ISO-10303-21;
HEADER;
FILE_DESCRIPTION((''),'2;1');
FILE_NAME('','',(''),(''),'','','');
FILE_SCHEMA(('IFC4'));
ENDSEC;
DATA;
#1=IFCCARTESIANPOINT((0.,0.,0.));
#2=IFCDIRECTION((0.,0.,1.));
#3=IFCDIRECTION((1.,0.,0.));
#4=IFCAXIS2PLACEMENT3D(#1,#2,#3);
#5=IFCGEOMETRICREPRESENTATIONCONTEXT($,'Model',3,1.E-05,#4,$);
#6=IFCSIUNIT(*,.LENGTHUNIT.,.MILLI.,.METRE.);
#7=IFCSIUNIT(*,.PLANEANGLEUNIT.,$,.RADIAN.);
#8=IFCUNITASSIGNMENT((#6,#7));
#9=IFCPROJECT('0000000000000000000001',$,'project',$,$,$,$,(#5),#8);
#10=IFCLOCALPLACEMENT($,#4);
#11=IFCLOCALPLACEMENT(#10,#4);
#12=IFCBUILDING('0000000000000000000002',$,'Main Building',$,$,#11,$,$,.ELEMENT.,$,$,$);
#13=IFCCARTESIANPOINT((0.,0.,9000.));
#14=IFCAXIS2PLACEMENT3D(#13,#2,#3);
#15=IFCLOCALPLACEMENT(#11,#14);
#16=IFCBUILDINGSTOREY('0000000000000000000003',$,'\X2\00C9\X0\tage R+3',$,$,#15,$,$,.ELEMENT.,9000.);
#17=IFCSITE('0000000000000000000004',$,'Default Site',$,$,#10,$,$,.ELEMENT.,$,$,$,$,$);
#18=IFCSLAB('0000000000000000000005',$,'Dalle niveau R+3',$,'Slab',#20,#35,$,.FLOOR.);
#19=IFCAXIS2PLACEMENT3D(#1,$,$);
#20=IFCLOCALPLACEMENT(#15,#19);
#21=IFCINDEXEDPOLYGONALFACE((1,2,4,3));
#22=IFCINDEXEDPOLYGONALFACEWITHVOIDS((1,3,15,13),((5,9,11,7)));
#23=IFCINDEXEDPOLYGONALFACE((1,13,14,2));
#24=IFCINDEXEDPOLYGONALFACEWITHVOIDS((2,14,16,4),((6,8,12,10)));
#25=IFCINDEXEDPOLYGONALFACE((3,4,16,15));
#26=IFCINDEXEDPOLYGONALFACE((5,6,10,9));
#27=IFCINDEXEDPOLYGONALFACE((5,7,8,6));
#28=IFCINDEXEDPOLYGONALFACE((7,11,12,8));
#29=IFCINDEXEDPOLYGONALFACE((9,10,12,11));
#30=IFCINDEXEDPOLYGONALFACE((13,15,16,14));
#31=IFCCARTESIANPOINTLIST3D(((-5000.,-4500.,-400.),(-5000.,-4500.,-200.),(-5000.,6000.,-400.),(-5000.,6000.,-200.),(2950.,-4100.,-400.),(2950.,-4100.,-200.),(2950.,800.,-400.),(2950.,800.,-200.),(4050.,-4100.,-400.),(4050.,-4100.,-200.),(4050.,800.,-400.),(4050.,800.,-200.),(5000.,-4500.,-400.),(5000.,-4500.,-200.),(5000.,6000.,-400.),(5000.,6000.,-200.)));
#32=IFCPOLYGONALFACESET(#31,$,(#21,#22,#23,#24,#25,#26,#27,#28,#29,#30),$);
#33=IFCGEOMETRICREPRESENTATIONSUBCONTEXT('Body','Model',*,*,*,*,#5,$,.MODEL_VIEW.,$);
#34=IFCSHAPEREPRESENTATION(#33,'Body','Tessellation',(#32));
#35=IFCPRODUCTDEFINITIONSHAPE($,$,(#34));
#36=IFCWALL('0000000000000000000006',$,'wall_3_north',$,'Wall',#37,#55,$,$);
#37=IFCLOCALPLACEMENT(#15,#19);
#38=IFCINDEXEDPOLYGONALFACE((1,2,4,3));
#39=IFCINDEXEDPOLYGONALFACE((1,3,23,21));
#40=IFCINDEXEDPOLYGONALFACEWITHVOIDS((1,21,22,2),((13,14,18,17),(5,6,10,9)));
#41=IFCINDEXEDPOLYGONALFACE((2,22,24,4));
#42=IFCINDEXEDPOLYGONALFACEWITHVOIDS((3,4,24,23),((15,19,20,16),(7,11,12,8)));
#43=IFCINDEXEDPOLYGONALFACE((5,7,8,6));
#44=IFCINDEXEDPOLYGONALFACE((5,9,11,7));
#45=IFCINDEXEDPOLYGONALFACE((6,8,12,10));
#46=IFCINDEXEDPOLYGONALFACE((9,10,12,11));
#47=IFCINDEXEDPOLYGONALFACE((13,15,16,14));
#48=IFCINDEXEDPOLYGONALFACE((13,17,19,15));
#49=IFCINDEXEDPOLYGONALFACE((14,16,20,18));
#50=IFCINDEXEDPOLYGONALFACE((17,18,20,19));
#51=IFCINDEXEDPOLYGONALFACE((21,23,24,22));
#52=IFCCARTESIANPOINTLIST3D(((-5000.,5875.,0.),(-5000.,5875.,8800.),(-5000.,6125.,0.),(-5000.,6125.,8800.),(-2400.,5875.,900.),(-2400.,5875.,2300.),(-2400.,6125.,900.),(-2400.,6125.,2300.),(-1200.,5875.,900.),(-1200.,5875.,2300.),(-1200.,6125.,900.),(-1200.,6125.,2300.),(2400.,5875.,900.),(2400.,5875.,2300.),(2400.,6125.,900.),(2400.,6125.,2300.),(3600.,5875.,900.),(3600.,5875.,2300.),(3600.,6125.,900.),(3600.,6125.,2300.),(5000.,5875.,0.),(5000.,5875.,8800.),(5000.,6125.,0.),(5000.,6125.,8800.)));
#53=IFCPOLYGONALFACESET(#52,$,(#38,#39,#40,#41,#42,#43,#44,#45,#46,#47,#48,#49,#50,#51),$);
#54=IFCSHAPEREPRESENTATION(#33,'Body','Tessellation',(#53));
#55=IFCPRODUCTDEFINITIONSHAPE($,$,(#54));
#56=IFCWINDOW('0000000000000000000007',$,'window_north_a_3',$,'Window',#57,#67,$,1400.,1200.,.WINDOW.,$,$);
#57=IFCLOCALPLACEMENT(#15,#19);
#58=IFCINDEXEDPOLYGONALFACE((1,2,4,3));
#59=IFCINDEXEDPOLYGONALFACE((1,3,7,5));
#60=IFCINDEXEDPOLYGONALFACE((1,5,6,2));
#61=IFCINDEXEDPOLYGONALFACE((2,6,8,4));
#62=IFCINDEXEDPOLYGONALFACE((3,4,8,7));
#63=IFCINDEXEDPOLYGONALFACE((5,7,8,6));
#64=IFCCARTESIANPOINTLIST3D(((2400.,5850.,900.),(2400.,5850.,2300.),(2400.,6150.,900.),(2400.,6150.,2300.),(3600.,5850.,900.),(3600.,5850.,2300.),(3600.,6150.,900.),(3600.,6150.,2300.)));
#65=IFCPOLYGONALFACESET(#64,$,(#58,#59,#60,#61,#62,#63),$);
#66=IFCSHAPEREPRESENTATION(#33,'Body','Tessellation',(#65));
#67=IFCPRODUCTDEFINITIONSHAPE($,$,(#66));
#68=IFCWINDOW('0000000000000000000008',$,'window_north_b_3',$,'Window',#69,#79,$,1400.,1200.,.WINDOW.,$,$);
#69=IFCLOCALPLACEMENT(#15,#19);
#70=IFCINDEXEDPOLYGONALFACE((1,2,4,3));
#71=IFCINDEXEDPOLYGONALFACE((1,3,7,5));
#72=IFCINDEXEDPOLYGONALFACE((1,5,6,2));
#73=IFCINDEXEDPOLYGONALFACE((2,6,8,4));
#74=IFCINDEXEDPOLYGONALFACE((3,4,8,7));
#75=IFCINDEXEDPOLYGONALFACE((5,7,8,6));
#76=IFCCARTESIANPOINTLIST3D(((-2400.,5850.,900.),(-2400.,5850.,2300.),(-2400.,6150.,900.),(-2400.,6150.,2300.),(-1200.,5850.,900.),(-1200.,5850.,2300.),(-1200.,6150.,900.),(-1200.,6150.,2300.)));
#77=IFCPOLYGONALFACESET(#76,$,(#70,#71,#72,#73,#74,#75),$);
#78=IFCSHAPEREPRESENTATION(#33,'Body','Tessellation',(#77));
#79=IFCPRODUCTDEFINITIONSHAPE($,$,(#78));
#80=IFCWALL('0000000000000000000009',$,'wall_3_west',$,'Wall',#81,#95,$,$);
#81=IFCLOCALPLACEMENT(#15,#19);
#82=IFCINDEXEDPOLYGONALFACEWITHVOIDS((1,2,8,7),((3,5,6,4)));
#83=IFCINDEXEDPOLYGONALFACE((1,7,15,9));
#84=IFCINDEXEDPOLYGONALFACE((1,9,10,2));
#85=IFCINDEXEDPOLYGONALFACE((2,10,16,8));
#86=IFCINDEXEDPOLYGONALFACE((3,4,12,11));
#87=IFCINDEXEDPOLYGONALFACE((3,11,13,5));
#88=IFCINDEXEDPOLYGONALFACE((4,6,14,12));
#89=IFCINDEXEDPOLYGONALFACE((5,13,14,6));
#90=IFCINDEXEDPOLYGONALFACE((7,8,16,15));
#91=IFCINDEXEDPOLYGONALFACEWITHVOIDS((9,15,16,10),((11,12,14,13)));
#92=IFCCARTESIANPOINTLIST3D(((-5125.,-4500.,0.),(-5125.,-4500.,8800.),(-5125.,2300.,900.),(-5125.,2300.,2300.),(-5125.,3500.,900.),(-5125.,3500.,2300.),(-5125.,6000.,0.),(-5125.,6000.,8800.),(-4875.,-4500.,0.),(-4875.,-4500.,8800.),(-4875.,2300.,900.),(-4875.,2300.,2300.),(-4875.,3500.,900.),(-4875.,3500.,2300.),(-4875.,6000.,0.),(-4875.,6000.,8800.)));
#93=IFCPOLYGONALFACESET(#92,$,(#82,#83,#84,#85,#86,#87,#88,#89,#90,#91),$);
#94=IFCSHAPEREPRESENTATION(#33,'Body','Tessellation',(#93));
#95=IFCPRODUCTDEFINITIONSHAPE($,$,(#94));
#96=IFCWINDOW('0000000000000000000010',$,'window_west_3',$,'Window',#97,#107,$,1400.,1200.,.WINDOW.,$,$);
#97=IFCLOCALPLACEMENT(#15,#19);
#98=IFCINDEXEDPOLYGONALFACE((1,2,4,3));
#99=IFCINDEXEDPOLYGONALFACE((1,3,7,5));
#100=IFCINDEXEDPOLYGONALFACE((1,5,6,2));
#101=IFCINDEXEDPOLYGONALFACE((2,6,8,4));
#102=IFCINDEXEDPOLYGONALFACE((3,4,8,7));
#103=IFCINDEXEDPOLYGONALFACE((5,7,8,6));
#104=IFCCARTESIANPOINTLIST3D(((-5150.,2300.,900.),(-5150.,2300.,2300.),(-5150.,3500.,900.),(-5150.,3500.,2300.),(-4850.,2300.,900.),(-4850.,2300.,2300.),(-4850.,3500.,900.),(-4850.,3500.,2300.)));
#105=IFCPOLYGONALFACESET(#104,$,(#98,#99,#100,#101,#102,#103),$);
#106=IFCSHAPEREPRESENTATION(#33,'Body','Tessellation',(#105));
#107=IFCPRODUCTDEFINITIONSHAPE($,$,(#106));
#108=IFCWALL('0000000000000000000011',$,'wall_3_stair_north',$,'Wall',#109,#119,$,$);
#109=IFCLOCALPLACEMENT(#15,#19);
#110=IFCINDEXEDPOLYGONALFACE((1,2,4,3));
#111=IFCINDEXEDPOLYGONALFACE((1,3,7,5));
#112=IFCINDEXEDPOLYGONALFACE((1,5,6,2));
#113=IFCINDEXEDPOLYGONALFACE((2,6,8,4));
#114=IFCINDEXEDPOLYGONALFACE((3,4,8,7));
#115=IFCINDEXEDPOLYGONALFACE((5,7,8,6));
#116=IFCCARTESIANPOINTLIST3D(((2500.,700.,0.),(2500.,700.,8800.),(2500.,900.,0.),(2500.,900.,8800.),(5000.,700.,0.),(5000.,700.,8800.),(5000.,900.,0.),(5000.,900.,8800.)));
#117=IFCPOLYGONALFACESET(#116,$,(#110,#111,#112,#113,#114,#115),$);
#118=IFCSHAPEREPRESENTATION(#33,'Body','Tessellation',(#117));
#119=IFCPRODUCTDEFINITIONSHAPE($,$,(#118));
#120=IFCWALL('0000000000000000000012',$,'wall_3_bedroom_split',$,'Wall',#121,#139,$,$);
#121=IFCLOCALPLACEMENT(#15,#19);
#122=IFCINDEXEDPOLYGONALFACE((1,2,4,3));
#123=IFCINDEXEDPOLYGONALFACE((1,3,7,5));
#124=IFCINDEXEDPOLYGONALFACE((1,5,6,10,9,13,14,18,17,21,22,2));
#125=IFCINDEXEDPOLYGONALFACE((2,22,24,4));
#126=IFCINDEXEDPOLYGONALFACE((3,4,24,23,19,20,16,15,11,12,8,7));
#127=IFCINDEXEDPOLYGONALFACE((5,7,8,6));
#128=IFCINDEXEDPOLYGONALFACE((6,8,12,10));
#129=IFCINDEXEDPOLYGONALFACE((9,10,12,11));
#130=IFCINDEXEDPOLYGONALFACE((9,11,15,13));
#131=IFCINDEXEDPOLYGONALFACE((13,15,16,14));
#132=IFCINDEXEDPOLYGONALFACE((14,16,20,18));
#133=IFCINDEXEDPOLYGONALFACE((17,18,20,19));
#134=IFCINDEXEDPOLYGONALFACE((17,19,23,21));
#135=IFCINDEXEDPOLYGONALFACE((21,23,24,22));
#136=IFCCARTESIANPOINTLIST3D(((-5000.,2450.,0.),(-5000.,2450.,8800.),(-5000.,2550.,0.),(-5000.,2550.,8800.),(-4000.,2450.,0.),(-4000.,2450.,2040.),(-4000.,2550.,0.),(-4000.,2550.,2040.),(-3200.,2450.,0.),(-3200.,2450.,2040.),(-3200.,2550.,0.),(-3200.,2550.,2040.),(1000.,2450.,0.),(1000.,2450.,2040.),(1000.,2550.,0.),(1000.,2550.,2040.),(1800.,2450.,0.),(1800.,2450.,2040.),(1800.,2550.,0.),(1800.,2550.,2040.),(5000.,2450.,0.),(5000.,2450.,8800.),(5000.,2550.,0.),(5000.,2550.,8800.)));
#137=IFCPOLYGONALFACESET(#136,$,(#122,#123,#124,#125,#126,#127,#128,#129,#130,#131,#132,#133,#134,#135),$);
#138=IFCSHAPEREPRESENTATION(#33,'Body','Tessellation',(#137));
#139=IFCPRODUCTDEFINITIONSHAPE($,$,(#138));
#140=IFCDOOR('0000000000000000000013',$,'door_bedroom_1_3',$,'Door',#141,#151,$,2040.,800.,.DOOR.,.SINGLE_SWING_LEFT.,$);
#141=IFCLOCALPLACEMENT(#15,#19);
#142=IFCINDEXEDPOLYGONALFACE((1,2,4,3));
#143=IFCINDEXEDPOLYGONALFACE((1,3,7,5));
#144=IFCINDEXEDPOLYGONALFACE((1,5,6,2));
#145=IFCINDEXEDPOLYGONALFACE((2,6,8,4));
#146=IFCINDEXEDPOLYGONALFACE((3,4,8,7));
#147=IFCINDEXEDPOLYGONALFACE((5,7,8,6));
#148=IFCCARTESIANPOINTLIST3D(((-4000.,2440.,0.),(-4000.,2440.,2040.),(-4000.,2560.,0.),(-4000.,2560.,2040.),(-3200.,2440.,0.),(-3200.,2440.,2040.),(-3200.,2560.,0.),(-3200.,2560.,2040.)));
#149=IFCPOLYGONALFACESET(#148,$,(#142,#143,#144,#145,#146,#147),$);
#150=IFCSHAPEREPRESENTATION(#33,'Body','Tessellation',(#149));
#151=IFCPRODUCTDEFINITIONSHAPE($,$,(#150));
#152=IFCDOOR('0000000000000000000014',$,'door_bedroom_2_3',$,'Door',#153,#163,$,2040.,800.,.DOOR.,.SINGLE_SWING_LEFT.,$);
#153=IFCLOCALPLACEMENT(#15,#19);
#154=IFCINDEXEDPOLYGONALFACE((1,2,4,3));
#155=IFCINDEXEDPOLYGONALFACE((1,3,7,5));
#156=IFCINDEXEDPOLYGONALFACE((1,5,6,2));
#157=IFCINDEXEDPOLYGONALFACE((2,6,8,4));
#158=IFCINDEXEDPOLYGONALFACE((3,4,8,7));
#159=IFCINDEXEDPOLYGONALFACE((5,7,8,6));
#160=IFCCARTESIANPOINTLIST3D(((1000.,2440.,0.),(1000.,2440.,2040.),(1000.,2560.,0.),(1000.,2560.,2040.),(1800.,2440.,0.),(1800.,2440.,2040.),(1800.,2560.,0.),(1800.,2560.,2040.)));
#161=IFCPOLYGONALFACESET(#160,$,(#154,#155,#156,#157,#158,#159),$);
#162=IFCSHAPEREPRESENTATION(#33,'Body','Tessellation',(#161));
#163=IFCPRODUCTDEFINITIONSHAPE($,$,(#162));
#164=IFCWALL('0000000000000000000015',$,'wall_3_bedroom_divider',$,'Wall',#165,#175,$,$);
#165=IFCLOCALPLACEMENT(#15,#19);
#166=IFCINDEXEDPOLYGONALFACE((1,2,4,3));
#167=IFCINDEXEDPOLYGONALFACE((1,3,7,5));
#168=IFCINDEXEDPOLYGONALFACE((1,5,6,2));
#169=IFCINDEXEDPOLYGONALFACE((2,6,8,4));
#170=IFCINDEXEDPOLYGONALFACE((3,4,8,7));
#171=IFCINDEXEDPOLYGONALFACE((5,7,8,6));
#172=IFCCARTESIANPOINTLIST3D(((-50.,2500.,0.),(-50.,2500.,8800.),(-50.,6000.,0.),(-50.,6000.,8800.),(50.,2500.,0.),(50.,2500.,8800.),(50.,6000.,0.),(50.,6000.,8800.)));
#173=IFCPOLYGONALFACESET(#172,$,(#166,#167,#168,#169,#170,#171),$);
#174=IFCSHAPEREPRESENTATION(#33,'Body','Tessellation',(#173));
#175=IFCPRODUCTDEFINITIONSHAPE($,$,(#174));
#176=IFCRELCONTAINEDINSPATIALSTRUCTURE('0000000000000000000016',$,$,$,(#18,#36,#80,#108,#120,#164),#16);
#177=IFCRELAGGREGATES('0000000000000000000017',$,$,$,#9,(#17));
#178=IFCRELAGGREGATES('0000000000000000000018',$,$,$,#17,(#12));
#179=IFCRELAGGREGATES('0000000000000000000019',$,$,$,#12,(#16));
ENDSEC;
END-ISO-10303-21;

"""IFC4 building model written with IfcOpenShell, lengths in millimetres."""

from ifc_helpers import new_model, si_unit, frame, origin_with_axes, place, context, subcontext, project, spatial, polyline, outline, extrude, element, fill, save


model = new_model("IFC4")

# Units and contexts
model_context = context("Model", 3, precision=1e-05, world=origin_with_axes())
body_context = subcontext(model_context, "Body", "Model", "MODEL_VIEW")
ifc_project = project(units=[si_unit("LENGTHUNIT", "METRE", prefix="MILLI"), si_unit("PLANEANGLEUNIT", "RADIAN")], contexts=[model_context])

# Site, building, storey
site_placement = place(None, origin_with_axes())
site = spatial("IfcSite", under=ifc_project, at=site_placement, Name="Default Site", CompositionType="ELEMENT")
building_placement = place(site_placement, origin_with_axes())
building = spatial("IfcBuilding", under=site, at=building_placement, Name="Main Building", CompositionType="ELEMENT")
storey_placement = place(building_placement, frame((0.0, 0.0, 9000.0), z_axis=(0.0, 0.0, 1.0), x_axis=(1.0, 0.0, 0.0)))
storey = spatial("IfcBuildingStorey", under=building, at=storey_placement, Name="Étage R+3", CompositionType="ELEMENT", Elevation=9000.0)

# Slab
slab_placement = place(storey_placement, frame((0.0, 0.0, -400.0), z_axis=(0.0, 0.0, 1.0), x_axis=(1.0, 0.0, 0.0)))
element("IfcSlab", 1, at=slab_placement, inside=storey, Name="Dalle niveau R+3", ObjectType="Slab", PredefinedType="FLOOR", context=body_context, shape_type="SweptSolid", body=[
    extrude(outline(polyline([(-5000.0, -4500.0), (5000.0, -4500.0), (5000.0, 6000.0), (-5000.0, 6000.0), (-5000.0, -4500.0)]), holes=[polyline([(2950.0, -4100.0), (2950.0, 800.0), (4050.0, 800.0), (4050.0, -4100.0), (2950.0, -4100.0)])]), origin_with_axes(), (0.0, 0.0, 1.0), 200.0),
])

# Wall, openings, windows
wall_1_placement = place(storey_placement, frame((5000.0, 6000.0, 0.0), z_axis=(0.0, 0.0, 1.0), x_axis=(-1.0, 0.0, 0.0)))
wall_1 = element("IfcWall", 2, at=wall_1_placement, inside=storey, Name="wall_3_north", ObjectType="Wall", context=body_context, shape_type="SweptSolid", body=[
    extrude(outline(polyline([(0.0, -125.0), (10000.0, -125.0), (10000.0, 125.0), (0.0, 125.0), (0.0, -125.0)])), origin_with_axes(), (0.0, 0.0, 1.0), 8800.0),
])
placement_1 = place(wall_1_placement, frame((1400.0, 0.0, 900.0), z_axis=(0.0, 0.0, 1.0), x_axis=(1.0, 0.0, 0.0)))
opening_1 = element("IfcOpeningElement", 3, at=placement_1, cuts=wall_1, PredefinedType="OPENING", context=body_context, shape_type="SweptSolid", body=[
    extrude(outline(polyline([(0.0, -150.0), (1200.0, -150.0), (1200.0, 150.0), (0.0, 150.0), (0.0, -150.0)])), origin_with_axes(), (0.0, 0.0, 1.0), 1400.0),
])
placement_2 = place(wall_1_placement, frame((6200.0, 0.0, 900.0), z_axis=(0.0, 0.0, 1.0), x_axis=(1.0, 0.0, 0.0)))
opening_2 = element("IfcOpeningElement", 4, at=placement_2, cuts=wall_1, PredefinedType="OPENING", context=body_context, shape_type="SweptSolid", body=[
    extrude(outline(polyline([(0.0, -150.0), (1200.0, -150.0), (1200.0, 150.0), (0.0, 150.0), (0.0, -150.0)])), origin_with_axes(), (0.0, 0.0, 1.0), 1400.0),
])
window_1 = element("IfcWindow", 5, at=placement_1, Name="window_north_a_3", ObjectType="Window", OverallHeight=1400.0, OverallWidth=1200.0, PredefinedType="WINDOW", context=body_context, shape_type="SweptSolid", body=[
    extrude(outline(polyline([(0.0, -150.0), (1200.0, -150.0), (1200.0, 150.0), (0.0, 150.0), (0.0, -150.0)])), origin_with_axes(), (0.0, 0.0, 1.0), 1400.0),
])
fill(opening_1, window_1)
window_2 = element("IfcWindow", 6, at=placement_2, Name="window_north_b_3", ObjectType="Window", OverallHeight=1400.0, OverallWidth=1200.0, PredefinedType="WINDOW", context=body_context, shape_type="SweptSolid", body=[
    extrude(outline(polyline([(0.0, -150.0), (1200.0, -150.0), (1200.0, 150.0), (0.0, 150.0), (0.0, -150.0)])), origin_with_axes(), (0.0, 0.0, 1.0), 1400.0),
])
fill(opening_2, window_2)

# Wall, opening, window
wall_2_placement = place(storey_placement, frame((-5000.0, 6000.0, 0.0), z_axis=(0.0, 0.0, 1.0), x_axis=(0.0, -1.0, 0.0)))
wall_2 = element("IfcWall", 7, at=wall_2_placement, inside=storey, Name="wall_3_west", ObjectType="Wall", context=body_context, shape_type="SweptSolid", body=[
    extrude(outline(polyline([(0.0, -125.0), (10500.0, -125.0), (10500.0, 125.0), (0.0, 125.0), (0.0, -125.0)])), origin_with_axes(), (0.0, 0.0, 1.0), 8800.0),
])
placement_3 = place(wall_2_placement, frame((2500.0, 0.0, 900.0), z_axis=(0.0, 0.0, 1.0), x_axis=(1.0, 0.0, 0.0)))
opening_3 = element("IfcOpeningElement", 8, at=placement_3, cuts=wall_2, PredefinedType="OPENING", context=body_context, shape_type="SweptSolid", body=[
    extrude(outline(polyline([(0.0, -150.0), (1200.0, -150.0), (1200.0, 150.0), (0.0, 150.0), (0.0, -150.0)])), origin_with_axes(), (0.0, 0.0, 1.0), 1400.0),
])
window_3 = element("IfcWindow", 9, at=placement_3, Name="window_west_3", ObjectType="Window", OverallHeight=1400.0, OverallWidth=1200.0, PredefinedType="WINDOW", context=body_context, shape_type="SweptSolid", body=[
    extrude(outline(polyline([(0.0, -150.0), (1200.0, -150.0), (1200.0, 150.0), (0.0, 150.0), (0.0, -150.0)])), origin_with_axes(), (0.0, 0.0, 1.0), 1400.0),
])
fill(opening_3, window_3)

# Wall
wall_3_placement = place(storey_placement, frame((2500.0, 800.0, 0.0), z_axis=(0.0, 0.0, 1.0), x_axis=(1.0, 0.0, 0.0)))
element("IfcWall", 10, at=wall_3_placement, inside=storey, Name="wall_3_stair_north", ObjectType="Wall", context=body_context, shape_type="SweptSolid", body=[
    extrude(outline(polyline([(0.0, -100.0), (2500.0, -100.0), (2500.0, 100.0), (0.0, 100.0), (0.0, -100.0)])), origin_with_axes(), (0.0, 0.0, 1.0), 8800.0),
])

# Wall, openings, doors
wall_4_placement = place(storey_placement, frame((-5000.0, 2500.0, 0.0), z_axis=(0.0, 0.0, 1.0), x_axis=(1.0, 0.0, 0.0)))
wall_4 = element("IfcWall", 11, at=wall_4_placement, inside=storey, Name="wall_3_bedroom_split", ObjectType="Wall", context=body_context, shape_type="SweptSolid", body=[
    extrude(outline(polyline([(0.0, -50.0), (10000.0, -50.0), (10000.0, 50.0), (0.0, 50.0), (0.0, -50.0)])), origin_with_axes(), (0.0, 0.0, 1.0), 8800.0),
])
placement_4 = place(wall_4_placement, frame((1000.0, 0.0, 0.0), z_axis=(0.0, 0.0, 1.0), x_axis=(1.0, 0.0, 0.0)))
opening_4 = element("IfcOpeningElement", 12, at=placement_4, cuts=wall_4, PredefinedType="OPENING", context=body_context, shape_type="SweptSolid", body=[
    extrude(outline(polyline([(0.0, -60.0), (800.0, -60.0), (800.0, 60.0), (0.0, 60.0), (0.0, -60.0)])), origin_with_axes(), (0.0, 0.0, 1.0), 2040.0),
])
placement_5 = place(wall_4_placement, frame((6000.0, 0.0, 0.0), z_axis=(0.0, 0.0, 1.0), x_axis=(1.0, 0.0, 0.0)))
opening_5 = element("IfcOpeningElement", 13, at=placement_5, cuts=wall_4, PredefinedType="OPENING", context=body_context, shape_type="SweptSolid", body=[
    extrude(outline(polyline([(0.0, -60.0), (800.0, -60.0), (800.0, 60.0), (0.0, 60.0), (0.0, -60.0)])), origin_with_axes(), (0.0, 0.0, 1.0), 2040.0),
])
door_1 = element("IfcDoor", 14, at=placement_4, Name="door_bedroom_1_3", ObjectType="Door", OperationType="SINGLE_SWING_LEFT", OverallHeight=2040.0, OverallWidth=800.0, PredefinedType="DOOR", context=body_context, shape_type="SweptSolid", body=[
    extrude(outline(polyline([(0.0, -60.0), (800.0, -60.0), (800.0, 60.0), (0.0, 60.0), (0.0, -60.0)])), origin_with_axes(), (0.0, 0.0, 1.0), 2040.0),
])
fill(opening_4, door_1)
door_2 = element("IfcDoor", 15, at=placement_5, Name="door_bedroom_2_3", ObjectType="Door", OperationType="SINGLE_SWING_LEFT", OverallHeight=2040.0, OverallWidth=800.0, PredefinedType="DOOR", context=body_context, shape_type="SweptSolid", body=[
    extrude(outline(polyline([(0.0, -60.0), (800.0, -60.0), (800.0, 60.0), (0.0, 60.0), (0.0, -60.0)])), origin_with_axes(), (0.0, 0.0, 1.0), 2040.0),
])
fill(opening_5, door_2)

# Wall
wall_5_placement = place(storey_placement, frame((0.0, 2500.0, 0.0), z_axis=(0.0, 0.0, 1.0), x_axis=(0.0, 1.0, 0.0)))
element("IfcWall", 16, at=wall_5_placement, inside=storey, Name="wall_3_bedroom_divider", ObjectType="Wall", context=body_context, shape_type="SweptSolid", body=[
    extrude(outline(polyline([(0.0, -50.0), (3500.0, -50.0), (3500.0, 50.0), (0.0, 50.0), (0.0, -50.0)])), origin_with_axes(), (0.0, 0.0, 1.0), 8800.0),
])

save(model, "model.ifc")
